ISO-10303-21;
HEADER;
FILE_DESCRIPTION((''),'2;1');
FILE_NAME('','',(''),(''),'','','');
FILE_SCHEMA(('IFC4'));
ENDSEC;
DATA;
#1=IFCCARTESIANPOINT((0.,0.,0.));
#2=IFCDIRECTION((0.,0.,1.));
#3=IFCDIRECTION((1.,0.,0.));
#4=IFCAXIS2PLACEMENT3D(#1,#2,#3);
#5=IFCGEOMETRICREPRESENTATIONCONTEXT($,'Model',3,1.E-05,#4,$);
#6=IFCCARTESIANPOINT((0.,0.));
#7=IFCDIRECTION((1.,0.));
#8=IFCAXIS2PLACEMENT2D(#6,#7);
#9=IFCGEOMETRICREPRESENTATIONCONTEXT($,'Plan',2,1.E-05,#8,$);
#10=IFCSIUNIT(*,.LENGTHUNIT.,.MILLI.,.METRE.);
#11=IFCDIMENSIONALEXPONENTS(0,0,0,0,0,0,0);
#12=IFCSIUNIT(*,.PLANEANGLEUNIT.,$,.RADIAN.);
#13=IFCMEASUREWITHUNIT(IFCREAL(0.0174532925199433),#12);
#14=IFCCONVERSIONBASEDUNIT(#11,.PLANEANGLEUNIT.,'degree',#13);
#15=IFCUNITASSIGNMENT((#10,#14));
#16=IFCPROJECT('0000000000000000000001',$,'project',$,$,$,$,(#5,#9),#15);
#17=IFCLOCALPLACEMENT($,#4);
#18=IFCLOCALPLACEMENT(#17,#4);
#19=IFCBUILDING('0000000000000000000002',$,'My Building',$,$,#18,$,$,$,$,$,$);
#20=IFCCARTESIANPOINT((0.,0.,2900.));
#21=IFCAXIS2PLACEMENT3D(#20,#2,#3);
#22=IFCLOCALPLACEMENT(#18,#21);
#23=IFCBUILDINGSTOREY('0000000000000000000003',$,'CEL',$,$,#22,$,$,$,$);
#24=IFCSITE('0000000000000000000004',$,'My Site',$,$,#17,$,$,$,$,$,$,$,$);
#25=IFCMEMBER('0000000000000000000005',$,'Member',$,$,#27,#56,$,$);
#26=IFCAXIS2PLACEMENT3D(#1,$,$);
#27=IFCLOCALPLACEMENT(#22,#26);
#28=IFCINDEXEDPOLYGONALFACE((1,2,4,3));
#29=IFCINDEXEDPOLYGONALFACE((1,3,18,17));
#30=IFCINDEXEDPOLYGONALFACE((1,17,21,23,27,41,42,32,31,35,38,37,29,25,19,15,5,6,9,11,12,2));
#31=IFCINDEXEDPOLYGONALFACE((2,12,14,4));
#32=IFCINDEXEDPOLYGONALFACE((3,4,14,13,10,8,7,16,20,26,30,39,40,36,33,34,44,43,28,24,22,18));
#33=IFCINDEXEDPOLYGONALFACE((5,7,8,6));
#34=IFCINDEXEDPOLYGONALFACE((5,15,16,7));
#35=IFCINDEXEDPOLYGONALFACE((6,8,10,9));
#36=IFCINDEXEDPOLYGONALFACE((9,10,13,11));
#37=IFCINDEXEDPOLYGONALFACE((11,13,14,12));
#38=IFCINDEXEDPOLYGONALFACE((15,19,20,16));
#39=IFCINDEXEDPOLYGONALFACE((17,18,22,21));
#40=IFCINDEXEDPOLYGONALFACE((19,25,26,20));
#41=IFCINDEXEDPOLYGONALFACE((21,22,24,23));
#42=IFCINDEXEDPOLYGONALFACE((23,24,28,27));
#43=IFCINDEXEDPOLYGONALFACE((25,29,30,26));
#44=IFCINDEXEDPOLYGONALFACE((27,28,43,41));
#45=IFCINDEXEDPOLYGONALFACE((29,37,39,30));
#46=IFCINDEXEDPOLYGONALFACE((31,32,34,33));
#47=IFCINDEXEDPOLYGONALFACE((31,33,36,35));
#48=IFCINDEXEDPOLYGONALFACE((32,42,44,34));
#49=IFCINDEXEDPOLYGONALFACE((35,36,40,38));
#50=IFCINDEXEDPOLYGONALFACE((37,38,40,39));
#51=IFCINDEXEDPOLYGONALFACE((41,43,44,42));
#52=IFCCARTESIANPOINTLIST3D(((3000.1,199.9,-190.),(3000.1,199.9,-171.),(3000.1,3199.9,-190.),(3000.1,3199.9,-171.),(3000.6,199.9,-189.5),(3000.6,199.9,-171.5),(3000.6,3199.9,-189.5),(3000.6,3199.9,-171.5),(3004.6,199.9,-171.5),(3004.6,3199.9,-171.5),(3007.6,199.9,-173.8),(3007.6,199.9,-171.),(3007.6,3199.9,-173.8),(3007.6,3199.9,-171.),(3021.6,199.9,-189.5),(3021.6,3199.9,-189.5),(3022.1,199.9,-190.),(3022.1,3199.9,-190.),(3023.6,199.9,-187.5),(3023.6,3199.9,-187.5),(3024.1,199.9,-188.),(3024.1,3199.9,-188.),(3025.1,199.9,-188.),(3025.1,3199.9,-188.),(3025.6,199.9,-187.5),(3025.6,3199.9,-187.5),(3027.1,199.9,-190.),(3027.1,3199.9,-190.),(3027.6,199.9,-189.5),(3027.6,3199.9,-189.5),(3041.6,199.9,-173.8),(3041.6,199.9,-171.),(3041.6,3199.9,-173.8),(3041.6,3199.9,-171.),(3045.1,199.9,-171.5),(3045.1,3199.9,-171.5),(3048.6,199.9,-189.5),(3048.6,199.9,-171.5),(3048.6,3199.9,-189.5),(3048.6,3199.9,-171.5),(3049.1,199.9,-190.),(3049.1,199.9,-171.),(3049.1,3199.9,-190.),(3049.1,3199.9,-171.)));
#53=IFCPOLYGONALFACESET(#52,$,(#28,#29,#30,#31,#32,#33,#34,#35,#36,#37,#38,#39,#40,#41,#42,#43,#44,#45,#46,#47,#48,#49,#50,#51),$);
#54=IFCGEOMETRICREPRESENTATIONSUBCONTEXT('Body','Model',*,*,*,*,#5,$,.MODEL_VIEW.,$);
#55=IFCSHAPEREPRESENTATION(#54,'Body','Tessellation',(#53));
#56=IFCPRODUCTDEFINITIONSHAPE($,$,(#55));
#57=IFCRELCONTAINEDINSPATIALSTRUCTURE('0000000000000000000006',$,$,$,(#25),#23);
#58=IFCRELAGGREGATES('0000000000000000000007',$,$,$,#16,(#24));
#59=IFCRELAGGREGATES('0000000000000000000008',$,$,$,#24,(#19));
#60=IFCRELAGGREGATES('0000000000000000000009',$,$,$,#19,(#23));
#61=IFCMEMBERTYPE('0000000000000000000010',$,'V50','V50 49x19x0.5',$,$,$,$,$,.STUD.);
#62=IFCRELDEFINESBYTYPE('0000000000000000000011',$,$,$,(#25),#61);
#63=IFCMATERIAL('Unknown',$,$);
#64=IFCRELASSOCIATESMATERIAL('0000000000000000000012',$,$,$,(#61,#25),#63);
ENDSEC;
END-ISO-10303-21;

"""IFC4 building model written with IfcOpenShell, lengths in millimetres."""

from ifc_helpers import new_model, entity, si_unit, converted_unit, frame, origin_with_axes, origin_2d_with_axis, place, context, subcontext, project, spatial, indexed_curve, outline, extrude, material, material_profile, profile_set, profile_usage, type_object, element, save


model = new_model("IFC4")

# Units and contexts
model_context = context("Model", 3, precision=1e-05, world=origin_with_axes())
plan_context = context("Plan", 2, precision=1e-05, world=origin_2d_with_axis())
body_context = subcontext(model_context, "Body", "Model", "MODEL_VIEW")
ifc_project = project(units=[si_unit("LENGTHUNIT", "METRE", prefix="MILLI"), converted_unit("PLANEANGLEUNIT", "degree", entity("IfcReal", 0.0174532925199433), si_unit("PLANEANGLEUNIT", "RADIAN"), dimensions=[0, 0, 0, 0, 0, 0, 0])], contexts=[model_context, plan_context])

# Site, building, storey
site_placement = place(None, origin_with_axes())
site = spatial("IfcSite", under=ifc_project, at=site_placement, Name="My Site")
building_placement = place(site_placement, origin_with_axes())
building = spatial("IfcBuilding", under=site, at=building_placement, Name="My Building")
storey_placement = place(building_placement, frame((0.0, 0.0, 2900.0), z_axis=(0.0, 0.0, 1.0), x_axis=(1.0, 0.0, 0.0)))
storey = spatial("IfcBuildingStorey", under=building, at=storey_placement, Name="CEL")

# Member
ifc_material = material(Name="Unknown")
ifc_material_profile = material_profile(ifc_material, outline(indexed_curve([(-49.0, 0.0), (-49.0, 19.0), (-41.5, 19.0), (-41.5, 16.2), (-45.0, 18.5), (-48.5, 18.5), (-48.5, 0.5), (-27.5, 0.5), (-25.5, 2.5), (-23.5, 2.5), (-21.5, 0.5), (-0.5, 0.5), (-0.5, 18.5), (-4.5, 18.5), (-7.5, 16.2), (-7.5, 19.0), (0.0, 19.0), (0.0, 0.0), (-22.0, 0.0), (-24.0, 2.0), (-25.0, 2.0), (-27.0, 0.0), (-49.0, 0.0)])))
ifc_profile_set = profile_set([ifc_material_profile])
member_type = type_object("IfcMemberType", Name="V50", Description="V50 49x19x0.5", PredefinedType="STUD", material=ifc_profile_set)
ifc_profile_usage_1 = profile_usage(ifc_profile_set, cardinal=5)
member_1_placement = place(storey_placement, frame((3000.1, 199.9, -190.0), z_axis=(0.0, 1.0, 0.0), x_axis=(-1.0, 0.0, 0.0)))
element("IfcMember", 1, at=member_1_placement, inside=storey, type_object=member_type, material=ifc_profile_usage_1, Name="Member", context=body_context, shape_type="SweptSolid", body=[
    extrude(outline(indexed_curve([(-49.0, 0.0), (-49.0, 19.0), (-41.5, 19.0), (-41.5, 16.2), (-45.0, 18.5), (-48.5, 18.5), (-48.5, 0.5), (-27.5, 0.5), (-25.5, 2.5), (-23.5, 2.5), (-21.5, 0.5), (-0.5, 0.5), (-0.5, 18.5), (-4.5, 18.5), (-7.5, 16.2), (-7.5, 19.0), (0.0, 19.0), (0.0, 0.0), (-22.0, 0.0), (-24.0, 2.0), (-25.0, 2.0), (-27.0, 0.0), (-49.0, 0.0)])), origin_with_axes(), (0.0, 0.0, 1.0), 3000.0),
])

save(model, "model.ifc")
